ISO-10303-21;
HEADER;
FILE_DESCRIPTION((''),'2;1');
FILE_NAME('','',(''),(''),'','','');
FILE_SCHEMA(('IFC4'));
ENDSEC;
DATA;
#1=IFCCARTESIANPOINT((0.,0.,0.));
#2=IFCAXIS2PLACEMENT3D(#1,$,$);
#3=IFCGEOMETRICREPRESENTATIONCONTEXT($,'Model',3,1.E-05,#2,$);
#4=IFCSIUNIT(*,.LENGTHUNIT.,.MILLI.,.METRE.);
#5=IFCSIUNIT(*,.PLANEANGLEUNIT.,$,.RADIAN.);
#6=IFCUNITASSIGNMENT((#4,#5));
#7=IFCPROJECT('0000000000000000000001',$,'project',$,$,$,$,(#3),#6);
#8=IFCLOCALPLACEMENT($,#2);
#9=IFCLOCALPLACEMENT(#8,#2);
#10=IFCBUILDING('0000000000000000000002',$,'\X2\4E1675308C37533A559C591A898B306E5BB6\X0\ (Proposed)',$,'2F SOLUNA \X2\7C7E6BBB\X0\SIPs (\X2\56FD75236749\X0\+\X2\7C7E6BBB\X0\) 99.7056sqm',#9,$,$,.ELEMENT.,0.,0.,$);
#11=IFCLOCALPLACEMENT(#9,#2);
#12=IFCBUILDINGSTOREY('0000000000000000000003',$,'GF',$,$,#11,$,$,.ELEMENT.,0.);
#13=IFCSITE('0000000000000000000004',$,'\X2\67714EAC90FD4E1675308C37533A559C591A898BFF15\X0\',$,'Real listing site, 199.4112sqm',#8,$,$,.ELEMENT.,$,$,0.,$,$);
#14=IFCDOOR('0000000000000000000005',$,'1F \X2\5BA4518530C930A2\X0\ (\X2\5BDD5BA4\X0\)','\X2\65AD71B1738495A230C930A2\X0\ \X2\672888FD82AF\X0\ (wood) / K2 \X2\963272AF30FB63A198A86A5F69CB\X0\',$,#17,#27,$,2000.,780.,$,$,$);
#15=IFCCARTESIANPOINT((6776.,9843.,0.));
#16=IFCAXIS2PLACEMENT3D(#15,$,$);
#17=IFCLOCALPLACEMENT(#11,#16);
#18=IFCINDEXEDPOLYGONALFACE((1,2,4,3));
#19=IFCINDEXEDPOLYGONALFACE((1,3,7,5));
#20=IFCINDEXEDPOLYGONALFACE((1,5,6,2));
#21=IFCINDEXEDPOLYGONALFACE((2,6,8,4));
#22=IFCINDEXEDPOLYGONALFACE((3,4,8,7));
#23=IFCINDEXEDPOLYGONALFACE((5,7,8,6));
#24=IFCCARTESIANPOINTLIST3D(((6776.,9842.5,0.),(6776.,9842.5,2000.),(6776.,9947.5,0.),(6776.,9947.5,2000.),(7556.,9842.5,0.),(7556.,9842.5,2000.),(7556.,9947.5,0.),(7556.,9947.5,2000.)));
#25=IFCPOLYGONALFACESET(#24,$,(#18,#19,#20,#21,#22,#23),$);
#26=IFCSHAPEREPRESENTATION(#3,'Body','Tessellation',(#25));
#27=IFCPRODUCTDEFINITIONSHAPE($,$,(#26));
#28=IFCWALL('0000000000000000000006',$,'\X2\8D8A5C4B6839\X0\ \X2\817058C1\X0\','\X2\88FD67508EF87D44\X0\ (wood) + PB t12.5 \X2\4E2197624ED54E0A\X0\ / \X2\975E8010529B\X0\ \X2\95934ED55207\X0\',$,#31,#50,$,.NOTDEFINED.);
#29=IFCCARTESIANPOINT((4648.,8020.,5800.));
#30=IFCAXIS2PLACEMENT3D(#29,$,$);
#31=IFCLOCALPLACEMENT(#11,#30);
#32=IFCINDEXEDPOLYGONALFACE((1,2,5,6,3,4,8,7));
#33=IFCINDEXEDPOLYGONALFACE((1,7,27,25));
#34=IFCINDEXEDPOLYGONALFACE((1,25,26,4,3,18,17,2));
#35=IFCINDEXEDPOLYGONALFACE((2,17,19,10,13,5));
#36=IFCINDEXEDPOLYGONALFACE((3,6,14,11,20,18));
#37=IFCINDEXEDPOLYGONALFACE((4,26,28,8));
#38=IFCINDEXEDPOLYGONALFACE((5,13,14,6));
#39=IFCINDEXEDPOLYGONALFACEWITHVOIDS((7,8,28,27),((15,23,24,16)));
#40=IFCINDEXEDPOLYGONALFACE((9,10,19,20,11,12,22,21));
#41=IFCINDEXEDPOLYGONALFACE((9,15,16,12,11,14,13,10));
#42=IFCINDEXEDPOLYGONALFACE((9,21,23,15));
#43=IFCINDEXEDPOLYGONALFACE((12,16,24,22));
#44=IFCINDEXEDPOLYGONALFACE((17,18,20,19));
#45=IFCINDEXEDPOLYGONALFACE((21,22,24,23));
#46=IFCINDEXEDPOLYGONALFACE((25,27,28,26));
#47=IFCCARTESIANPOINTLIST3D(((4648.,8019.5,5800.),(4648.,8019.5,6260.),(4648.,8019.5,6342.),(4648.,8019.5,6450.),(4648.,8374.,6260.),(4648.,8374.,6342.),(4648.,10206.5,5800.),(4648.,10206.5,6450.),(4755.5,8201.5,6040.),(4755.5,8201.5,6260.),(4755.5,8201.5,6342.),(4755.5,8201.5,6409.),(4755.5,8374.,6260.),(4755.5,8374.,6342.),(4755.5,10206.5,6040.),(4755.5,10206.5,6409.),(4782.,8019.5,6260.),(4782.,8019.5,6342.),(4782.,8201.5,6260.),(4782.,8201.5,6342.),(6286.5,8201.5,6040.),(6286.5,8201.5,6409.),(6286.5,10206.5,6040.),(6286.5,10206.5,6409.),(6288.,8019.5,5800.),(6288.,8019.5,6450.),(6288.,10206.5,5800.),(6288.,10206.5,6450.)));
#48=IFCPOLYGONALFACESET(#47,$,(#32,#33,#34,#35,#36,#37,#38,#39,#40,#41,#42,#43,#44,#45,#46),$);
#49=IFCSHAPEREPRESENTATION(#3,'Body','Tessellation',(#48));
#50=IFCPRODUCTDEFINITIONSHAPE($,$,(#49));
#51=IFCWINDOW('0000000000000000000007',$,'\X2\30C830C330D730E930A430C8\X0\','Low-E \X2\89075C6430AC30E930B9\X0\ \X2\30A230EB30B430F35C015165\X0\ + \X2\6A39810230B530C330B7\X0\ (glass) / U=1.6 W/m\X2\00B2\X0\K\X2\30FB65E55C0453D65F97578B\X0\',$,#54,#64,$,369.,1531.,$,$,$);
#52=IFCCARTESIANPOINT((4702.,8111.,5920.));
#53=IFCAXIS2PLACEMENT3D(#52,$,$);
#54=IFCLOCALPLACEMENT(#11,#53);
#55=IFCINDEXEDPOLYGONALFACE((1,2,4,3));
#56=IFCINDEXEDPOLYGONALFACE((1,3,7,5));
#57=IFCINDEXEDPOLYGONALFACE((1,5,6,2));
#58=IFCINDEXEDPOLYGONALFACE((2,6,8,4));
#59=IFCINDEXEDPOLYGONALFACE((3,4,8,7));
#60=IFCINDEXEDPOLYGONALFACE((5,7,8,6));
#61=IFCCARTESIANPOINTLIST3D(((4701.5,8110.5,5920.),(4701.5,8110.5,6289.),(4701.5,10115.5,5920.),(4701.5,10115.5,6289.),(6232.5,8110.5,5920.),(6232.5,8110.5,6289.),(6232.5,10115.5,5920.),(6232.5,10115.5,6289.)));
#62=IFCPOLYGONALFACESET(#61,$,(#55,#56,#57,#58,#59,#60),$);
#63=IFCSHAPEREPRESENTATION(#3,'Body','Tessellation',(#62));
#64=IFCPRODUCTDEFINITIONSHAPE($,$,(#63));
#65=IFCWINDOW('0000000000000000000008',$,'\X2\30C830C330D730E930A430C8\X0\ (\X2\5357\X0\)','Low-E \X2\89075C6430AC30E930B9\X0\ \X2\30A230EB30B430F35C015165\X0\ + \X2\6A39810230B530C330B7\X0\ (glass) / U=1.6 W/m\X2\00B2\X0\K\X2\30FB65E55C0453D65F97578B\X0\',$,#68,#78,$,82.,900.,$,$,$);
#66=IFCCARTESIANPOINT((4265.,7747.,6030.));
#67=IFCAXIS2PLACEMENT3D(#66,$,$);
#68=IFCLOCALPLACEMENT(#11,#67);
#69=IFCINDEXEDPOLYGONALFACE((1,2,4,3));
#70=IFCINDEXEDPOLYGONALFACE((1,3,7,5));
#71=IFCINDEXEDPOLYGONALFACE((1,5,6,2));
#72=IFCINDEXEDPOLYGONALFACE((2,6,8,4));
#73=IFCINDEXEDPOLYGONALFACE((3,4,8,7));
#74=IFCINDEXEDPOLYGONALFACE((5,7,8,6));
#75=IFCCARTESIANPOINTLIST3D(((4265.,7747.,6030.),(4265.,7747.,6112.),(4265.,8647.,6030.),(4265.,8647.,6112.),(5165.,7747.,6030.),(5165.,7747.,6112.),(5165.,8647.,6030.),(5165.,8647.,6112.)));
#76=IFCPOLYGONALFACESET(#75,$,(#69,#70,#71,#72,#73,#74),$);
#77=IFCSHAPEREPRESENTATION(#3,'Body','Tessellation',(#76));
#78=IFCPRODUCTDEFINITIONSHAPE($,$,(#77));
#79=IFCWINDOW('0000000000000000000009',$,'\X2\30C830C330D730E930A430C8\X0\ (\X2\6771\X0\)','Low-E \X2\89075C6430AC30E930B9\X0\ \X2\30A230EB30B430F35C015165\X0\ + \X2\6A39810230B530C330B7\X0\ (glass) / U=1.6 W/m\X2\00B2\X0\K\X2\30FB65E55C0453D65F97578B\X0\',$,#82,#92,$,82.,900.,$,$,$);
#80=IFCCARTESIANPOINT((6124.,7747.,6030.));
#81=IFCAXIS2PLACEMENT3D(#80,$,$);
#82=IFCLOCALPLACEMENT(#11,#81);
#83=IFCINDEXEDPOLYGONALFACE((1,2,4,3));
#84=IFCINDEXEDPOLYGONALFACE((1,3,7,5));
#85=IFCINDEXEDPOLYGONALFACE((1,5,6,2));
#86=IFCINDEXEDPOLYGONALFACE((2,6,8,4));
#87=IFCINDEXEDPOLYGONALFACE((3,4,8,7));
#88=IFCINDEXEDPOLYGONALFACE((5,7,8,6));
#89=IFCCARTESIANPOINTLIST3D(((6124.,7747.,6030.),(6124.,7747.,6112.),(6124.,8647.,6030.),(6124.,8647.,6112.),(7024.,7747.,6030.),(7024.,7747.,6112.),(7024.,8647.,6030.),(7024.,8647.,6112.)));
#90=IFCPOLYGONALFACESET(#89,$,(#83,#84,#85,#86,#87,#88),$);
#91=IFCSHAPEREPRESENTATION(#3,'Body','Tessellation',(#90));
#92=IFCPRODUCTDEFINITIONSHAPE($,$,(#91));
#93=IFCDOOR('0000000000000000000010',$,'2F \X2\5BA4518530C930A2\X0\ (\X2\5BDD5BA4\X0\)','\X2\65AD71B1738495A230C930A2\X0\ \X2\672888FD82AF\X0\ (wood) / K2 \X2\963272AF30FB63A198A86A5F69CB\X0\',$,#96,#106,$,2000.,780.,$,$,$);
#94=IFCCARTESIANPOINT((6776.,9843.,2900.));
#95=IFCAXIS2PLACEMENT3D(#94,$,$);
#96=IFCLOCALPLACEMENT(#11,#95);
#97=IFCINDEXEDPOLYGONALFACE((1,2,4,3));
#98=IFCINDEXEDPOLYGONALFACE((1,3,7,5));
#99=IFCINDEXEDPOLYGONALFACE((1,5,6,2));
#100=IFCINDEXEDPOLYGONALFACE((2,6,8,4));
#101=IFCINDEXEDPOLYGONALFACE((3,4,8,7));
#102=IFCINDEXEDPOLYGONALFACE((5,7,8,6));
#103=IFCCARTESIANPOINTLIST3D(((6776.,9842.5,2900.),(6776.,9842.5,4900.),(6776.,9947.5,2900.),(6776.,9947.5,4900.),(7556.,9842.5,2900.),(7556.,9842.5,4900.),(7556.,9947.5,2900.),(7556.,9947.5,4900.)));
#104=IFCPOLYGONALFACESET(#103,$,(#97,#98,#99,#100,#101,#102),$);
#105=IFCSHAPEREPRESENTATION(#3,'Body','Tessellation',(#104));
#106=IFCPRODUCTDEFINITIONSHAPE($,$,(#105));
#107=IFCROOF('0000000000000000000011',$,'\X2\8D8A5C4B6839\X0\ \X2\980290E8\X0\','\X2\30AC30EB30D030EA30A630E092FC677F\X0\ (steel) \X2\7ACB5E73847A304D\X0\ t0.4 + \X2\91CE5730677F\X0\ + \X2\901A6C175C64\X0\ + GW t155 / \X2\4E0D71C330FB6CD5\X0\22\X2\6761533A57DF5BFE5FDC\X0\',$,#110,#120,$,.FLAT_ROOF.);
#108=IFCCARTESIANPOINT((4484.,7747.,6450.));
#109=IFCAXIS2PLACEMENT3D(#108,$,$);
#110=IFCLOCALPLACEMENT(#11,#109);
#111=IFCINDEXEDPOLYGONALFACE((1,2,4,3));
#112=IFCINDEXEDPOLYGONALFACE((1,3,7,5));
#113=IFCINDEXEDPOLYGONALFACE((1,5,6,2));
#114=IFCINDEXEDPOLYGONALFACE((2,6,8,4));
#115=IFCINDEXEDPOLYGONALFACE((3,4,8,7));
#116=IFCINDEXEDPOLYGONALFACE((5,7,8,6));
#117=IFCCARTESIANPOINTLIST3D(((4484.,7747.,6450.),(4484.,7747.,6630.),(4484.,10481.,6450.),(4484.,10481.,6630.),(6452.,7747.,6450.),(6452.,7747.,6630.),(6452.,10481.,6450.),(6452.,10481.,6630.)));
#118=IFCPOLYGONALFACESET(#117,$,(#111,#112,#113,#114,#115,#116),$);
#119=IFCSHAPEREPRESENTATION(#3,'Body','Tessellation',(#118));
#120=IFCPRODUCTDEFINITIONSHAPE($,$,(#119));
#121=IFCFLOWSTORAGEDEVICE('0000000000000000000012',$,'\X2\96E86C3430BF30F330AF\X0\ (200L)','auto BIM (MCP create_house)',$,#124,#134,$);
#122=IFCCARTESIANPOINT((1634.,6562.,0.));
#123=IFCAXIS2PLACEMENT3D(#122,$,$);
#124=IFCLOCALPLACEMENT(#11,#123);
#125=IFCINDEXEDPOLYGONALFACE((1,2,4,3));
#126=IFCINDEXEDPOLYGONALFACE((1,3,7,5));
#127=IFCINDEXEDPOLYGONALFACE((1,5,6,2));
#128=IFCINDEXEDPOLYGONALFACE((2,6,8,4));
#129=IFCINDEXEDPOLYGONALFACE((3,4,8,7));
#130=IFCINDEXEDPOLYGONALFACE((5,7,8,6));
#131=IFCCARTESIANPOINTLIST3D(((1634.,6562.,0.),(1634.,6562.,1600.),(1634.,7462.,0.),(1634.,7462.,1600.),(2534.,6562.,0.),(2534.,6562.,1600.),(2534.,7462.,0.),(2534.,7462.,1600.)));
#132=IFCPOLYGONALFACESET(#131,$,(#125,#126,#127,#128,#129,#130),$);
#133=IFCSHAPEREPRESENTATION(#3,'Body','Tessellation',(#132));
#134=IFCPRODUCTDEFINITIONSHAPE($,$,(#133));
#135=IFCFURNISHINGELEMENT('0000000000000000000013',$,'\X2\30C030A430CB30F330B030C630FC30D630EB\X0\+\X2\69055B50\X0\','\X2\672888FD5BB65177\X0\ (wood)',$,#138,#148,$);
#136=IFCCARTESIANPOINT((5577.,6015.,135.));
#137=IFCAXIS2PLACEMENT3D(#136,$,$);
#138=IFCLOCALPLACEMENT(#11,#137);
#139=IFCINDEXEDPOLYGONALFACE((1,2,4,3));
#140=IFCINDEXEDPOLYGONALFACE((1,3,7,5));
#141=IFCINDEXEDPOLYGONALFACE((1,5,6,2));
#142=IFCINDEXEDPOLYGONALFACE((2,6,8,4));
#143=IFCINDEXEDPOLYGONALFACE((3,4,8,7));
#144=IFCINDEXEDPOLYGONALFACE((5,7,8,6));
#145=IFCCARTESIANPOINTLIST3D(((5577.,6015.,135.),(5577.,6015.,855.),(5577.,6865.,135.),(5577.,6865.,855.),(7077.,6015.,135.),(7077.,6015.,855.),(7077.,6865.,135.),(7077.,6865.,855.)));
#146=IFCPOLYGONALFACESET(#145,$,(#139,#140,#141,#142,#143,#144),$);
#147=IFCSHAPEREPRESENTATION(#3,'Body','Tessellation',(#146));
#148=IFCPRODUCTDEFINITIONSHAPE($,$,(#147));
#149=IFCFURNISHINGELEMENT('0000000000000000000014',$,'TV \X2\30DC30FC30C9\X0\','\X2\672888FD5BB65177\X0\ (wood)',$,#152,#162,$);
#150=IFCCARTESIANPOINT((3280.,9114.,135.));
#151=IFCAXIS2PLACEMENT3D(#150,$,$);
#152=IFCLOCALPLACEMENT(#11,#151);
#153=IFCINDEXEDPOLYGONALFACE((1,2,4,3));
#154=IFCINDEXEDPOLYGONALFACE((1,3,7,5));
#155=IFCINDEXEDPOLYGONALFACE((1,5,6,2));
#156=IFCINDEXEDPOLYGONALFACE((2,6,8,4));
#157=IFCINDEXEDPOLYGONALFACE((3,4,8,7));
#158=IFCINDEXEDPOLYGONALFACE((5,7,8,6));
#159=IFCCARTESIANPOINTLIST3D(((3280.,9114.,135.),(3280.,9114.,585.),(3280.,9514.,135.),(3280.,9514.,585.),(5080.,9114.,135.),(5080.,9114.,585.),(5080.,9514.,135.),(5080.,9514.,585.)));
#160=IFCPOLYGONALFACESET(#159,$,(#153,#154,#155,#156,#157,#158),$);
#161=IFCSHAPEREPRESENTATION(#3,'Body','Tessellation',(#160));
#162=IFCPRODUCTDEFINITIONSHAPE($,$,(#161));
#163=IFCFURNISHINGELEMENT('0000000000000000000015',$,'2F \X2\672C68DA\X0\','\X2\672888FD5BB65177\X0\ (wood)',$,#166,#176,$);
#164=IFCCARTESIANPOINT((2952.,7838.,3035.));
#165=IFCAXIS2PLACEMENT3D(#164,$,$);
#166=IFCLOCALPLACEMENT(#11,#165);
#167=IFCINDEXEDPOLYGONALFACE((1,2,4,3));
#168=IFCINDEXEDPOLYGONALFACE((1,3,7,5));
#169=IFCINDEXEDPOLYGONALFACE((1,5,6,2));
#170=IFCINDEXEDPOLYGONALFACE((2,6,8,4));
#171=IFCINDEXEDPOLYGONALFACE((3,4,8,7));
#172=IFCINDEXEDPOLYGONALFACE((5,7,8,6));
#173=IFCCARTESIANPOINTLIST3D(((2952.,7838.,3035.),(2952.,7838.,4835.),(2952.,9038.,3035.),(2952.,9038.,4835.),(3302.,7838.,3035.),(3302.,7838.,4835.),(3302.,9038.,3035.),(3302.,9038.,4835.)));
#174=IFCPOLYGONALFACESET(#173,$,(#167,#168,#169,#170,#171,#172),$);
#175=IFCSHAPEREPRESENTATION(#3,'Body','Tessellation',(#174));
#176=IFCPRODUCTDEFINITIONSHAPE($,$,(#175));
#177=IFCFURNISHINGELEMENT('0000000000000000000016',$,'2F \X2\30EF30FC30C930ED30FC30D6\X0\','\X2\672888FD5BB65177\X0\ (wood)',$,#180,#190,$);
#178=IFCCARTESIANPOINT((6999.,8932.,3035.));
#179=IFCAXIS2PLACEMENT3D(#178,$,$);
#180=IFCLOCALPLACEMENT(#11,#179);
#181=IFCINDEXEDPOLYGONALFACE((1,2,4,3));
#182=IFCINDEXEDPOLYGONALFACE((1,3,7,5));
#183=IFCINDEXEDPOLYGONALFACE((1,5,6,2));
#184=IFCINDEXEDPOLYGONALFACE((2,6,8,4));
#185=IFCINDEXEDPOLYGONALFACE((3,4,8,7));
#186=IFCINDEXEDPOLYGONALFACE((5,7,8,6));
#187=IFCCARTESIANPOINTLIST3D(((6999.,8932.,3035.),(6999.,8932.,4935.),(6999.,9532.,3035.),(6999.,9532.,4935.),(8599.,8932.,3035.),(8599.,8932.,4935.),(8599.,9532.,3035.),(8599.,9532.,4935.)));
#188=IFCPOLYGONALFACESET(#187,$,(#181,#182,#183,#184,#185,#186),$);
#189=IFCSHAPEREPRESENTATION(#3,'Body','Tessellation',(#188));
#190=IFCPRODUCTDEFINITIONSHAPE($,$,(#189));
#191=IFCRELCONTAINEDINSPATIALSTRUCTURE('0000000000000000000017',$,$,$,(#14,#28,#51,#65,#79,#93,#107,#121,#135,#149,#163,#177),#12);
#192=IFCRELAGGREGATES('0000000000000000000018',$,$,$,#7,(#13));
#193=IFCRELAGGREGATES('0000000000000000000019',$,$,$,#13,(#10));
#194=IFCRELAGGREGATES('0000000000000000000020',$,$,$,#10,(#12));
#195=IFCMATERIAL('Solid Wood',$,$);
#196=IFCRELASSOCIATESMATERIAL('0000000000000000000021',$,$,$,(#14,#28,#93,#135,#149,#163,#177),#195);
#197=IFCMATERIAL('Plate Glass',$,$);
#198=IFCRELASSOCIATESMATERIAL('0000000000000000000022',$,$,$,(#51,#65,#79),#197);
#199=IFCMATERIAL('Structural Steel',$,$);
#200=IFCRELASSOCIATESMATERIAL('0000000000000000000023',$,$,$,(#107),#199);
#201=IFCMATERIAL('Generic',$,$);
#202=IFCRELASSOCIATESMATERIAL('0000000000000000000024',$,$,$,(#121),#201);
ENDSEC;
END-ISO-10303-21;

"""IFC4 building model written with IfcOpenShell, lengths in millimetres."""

from ifc_helpers import new_model, si_unit, frame, frame_2d, origin, place, context, project, spatial, rectangle, extrude, material, element, fill, save


model = new_model("IFC4")

# Units and contexts
model_context = context("Model", 3, precision=1e-05, world=origin())
ifc_project = project(units=[si_unit("LENGTHUNIT", "METRE", prefix="MILLI"), si_unit("PLANEANGLEUNIT", "RADIAN")], contexts=[model_context])

# Site, building, storey
site_placement = place(None, origin())
site = spatial("IfcSite", under=ifc_project, at=site_placement, Name="東京都世田谷区喜多見５", ObjectType="Real listing site, 199.4112sqm", CompositionType="ELEMENT", RefElevation=0.0)
building_placement = place(site_placement, origin())
building = spatial("IfcBuilding", under=site, at=building_placement, Name="世田谷区喜多見の家 (Proposed)", ObjectType="2F SOLUNA 籾殻SIPs (国産杉+籾殻) 99.7056sqm", CompositionType="ELEMENT", ElevationOfRefHeight=0.0, ElevationOfTerrain=0.0)
storey_placement = place(building_placement, origin())
storey = spatial("IfcBuildingStorey", under=building, at=storey_placement, Name="GF", CompositionType="ELEMENT", Elevation=0.0)

# Shared definitions
ifc_material_1 = material(Name="Solid Wood")

# Door
door_1_placement = place(storey_placement, frame((6776.0, 9843.0, 0.0)))
element("IfcDoor", 1, at=door_1_placement, inside=storey, material=ifc_material_1, Name="1F 室内ドア (寝室)", Description="断熱玄関ドア 木製芯 (wood) / K2 防犯・採風機構", OverallHeight=2000.0, OverallWidth=780.0, context=model_context, shape_type="SweptSolid", body=[
    extrude(rectangle(XDim=780.0, YDim=105.0, at=frame_2d((390.0, 52.0))), frame((6776.0, 9843.0, 0.0)), (0.0, 0.0, 1.0), 2000.0),
])

# Wall, openings, windows
wall_1_placement = place(storey_placement, frame((4648.0, 8020.0, 5800.0)))
wall_1 = element("IfcWall", 2, at=wall_1_placement, inside=storey, material=ifc_material_1, Name="越屋根 腰壁", Description="製材軸組 (wood) + PB t12.5 両面仕上 / 非耐力 間仕切", PredefinedType="NOTDEFINED", context=model_context, shape_type="SweptSolid", body=[
    extrude(rectangle(XDim=1640.0, YDim=2187.0, at=frame_2d((820.0, 1093.0))), frame((4648.0, 8020.0, 5800.0)), (0.0, 0.0, 1.0), 650.0),
])
opening_1_placement = place(storey_placement, frame((4702.0, 8111.0, 5920.0)))
opening_1 = element("IfcOpeningElement", 3, at=opening_1_placement, cuts=wall_1, PredefinedType="NOTDEFINED", context=model_context, shape_type="SweptSolid", body=[
    extrude(rectangle(XDim=1531.0, YDim=2005.0, at=frame_2d((765.0, 1002.0))), frame((4702.0, 8111.0, 5920.0)), (0.0, 0.0, 1.0), 369.0),
])
opening_2_placement = place(storey_placement, frame((4265.0, 7747.0, 6030.0)))
opening_2 = element("IfcOpeningElement", 4, at=opening_2_placement, cuts=wall_1, PredefinedType="NOTDEFINED", context=model_context, shape_type="SweptSolid", body=[
    extrude(rectangle(XDim=900.0, YDim=900.0, at=frame_2d((450.0, 450.0))), frame((4265.0, 7747.0, 6030.0)), (0.0, 0.0, 1.0), 82.0),
])
opening_3_placement = place(storey_placement, frame((6124.0, 7747.0, 6030.0)))
opening_3 = element("IfcOpeningElement", 5, at=opening_3_placement, cuts=wall_1, PredefinedType="NOTDEFINED", context=model_context, shape_type="SweptSolid", body=[
    extrude(rectangle(XDim=900.0, YDim=900.0, at=frame_2d((450.0, 450.0))), frame((6124.0, 7747.0, 6030.0)), (0.0, 0.0, 1.0), 82.0),
])
ifc_material_2 = material(Name="Plate Glass")
window_1_placement = place(storey_placement, frame((4702.0, 8111.0, 5920.0)))
window_1 = element("IfcWindow", 6, at=window_1_placement, inside=storey, material=ifc_material_2, Name="トップライト", Description="Low-E 複層ガラス アルゴン封入 + 樹脂サッシ (glass) / U=1.6 W/m²K・日射取得型", OverallHeight=369.0, OverallWidth=1531.0, context=model_context, shape_type="SweptSolid", body=[
    extrude(rectangle(XDim=1531.0, YDim=2005.0, at=frame_2d((765.0, 1002.0))), frame((4702.0, 8111.0, 5920.0)), (0.0, 0.0, 1.0), 369.0),
])
fill(opening_1, window_1)
window_2_placement = place(storey_placement, frame((4265.0, 7747.0, 6030.0)))
window_2 = element("IfcWindow", 7, at=window_2_placement, inside=storey, material=ifc_material_2, Name="トップライト (南)", Description="Low-E 複層ガラス アルゴン封入 + 樹脂サッシ (glass) / U=1.6 W/m²K・日射取得型", OverallHeight=82.0, OverallWidth=900.0, context=model_context, shape_type="SweptSolid", body=[
    extrude(rectangle(XDim=900.0, YDim=900.0, at=frame_2d((450.0, 450.0))), frame((4265.0, 7747.0, 6030.0)), (0.0, 0.0, 1.0), 82.0),
])
fill(opening_2, window_2)
window_3_placement = place(storey_placement, frame((6124.0, 7747.0, 6030.0)))
window_3 = element("IfcWindow", 8, at=window_3_placement, inside=storey, material=ifc_material_2, Name="トップライト (東)", Description="Low-E 複層ガラス アルゴン封入 + 樹脂サッシ (glass) / U=1.6 W/m²K・日射取得型", OverallHeight=82.0, OverallWidth=900.0, context=model_context, shape_type="SweptSolid", body=[
    extrude(rectangle(XDim=900.0, YDim=900.0, at=frame_2d((450.0, 450.0))), frame((6124.0, 7747.0, 6030.0)), (0.0, 0.0, 1.0), 82.0),
])
fill(opening_3, window_3)

# Door
door_2_placement = place(storey_placement, frame((6776.0, 9843.0, 2900.0)))
element("IfcDoor", 9, at=door_2_placement, inside=storey, material=ifc_material_1, Name="2F 室内ドア (寝室)", Description="断熱玄関ドア 木製芯 (wood) / K2 防犯・採風機構", OverallHeight=2000.0, OverallWidth=780.0, context=model_context, shape_type="SweptSolid", body=[
    extrude(rectangle(XDim=780.0, YDim=105.0, at=frame_2d((390.0, 52.0))), frame((6776.0, 9843.0, 2900.0)), (0.0, 0.0, 1.0), 2000.0),
])

# Roof
ifc_material_3 = material(Name="Structural Steel")
roof_placement = place(storey_placement, frame((4484.0, 7747.0, 6450.0)))
element("IfcRoof", 10, at=roof_placement, inside=storey, material=ifc_material_3, Name="越屋根 頂部", Description="ガルバリウム鋼板 (steel) 立平葺き t0.4 + 野地板 + 通気層 + GW t155 / 不燃・法22条区域対応", PredefinedType="FLAT_ROOF", context=model_context, shape_type="SweptSolid", body=[
    extrude(rectangle(XDim=1968.0, YDim=2734.0, at=frame_2d((984.0, 1367.0))), frame((4484.0, 7747.0, 6450.0)), (0.0, 0.0, 1.0), 180.0),
])

# Flow storage device
ifc_material_4 = material(Name="Generic")
flow_storage_device_placement = place(storey_placement, frame((1634.0, 6562.0, 0.0)))
element("IfcFlowStorageDevice", 11, at=flow_storage_device_placement, inside=storey, material=ifc_material_4, Name="雨水タンク (200L)", Description="auto BIM (MCP create_house)", context=model_context, shape_type="SweptSolid", body=[
    extrude(rectangle(XDim=900.0, YDim=900.0, at=frame_2d((450.0, 450.0))), frame((1634.0, 6562.0, 0.0)), (0.0, 0.0, 1.0), 1600.0),
])

# Furnishing elements
furnishing_1_placement = place(storey_placement, frame((5577.0, 6015.0, 135.0)))
element("IfcFurnishingElement", 12, at=furnishing_1_placement, inside=storey, material=ifc_material_1, Name="ダイニングテーブル+椅子", Description="木製家具 (wood)", context=model_context, shape_type="SweptSolid", body=[
    extrude(rectangle(XDim=1500.0, YDim=850.0, at=frame_2d((750.0, 425.0))), frame((5577.0, 6015.0, 135.0)), (0.0, 0.0, 1.0), 720.0),
])
furnishing_2_placement = place(storey_placement, frame((3280.0, 9114.0, 135.0)))
element("IfcFurnishingElement", 13, at=furnishing_2_placement, inside=storey, material=ifc_material_1, Name="TV ボード", Description="木製家具 (wood)", context=model_context, shape_type="SweptSolid", body=[
    extrude(rectangle(XDim=1800.0, YDim=400.0, at=frame_2d((900.0, 200.0))), frame((3280.0, 9114.0, 135.0)), (0.0, 0.0, 1.0), 450.0),
])
furnishing_3_placement = place(storey_placement, frame((2952.0, 7838.0, 3035.0)))
element("IfcFurnishingElement", 14, at=furnishing_3_placement, inside=storey, material=ifc_material_1, Name="2F 本棚", Description="木製家具 (wood)", context=model_context, shape_type="SweptSolid", body=[
    extrude(rectangle(XDim=350.0, YDim=1200.0, at=frame_2d((175.0, 600.0))), frame((2952.0, 7838.0, 3035.0)), (0.0, 0.0, 1.0), 1800.0),
])
furnishing_4_placement = place(storey_placement, frame((6999.0, 8932.0, 3035.0)))
element("IfcFurnishingElement", 15, at=furnishing_4_placement, inside=storey, material=ifc_material_1, Name="2F ワードローブ", Description="木製家具 (wood)", context=model_context, shape_type="SweptSolid", body=[
    extrude(rectangle(XDim=1600.0, YDim=600.0, at=frame_2d((800.0, 300.0))), frame((6999.0, 8932.0, 3035.0)), (0.0, 0.0, 1.0), 1900.0),
])

save(model, "model.ifc")
